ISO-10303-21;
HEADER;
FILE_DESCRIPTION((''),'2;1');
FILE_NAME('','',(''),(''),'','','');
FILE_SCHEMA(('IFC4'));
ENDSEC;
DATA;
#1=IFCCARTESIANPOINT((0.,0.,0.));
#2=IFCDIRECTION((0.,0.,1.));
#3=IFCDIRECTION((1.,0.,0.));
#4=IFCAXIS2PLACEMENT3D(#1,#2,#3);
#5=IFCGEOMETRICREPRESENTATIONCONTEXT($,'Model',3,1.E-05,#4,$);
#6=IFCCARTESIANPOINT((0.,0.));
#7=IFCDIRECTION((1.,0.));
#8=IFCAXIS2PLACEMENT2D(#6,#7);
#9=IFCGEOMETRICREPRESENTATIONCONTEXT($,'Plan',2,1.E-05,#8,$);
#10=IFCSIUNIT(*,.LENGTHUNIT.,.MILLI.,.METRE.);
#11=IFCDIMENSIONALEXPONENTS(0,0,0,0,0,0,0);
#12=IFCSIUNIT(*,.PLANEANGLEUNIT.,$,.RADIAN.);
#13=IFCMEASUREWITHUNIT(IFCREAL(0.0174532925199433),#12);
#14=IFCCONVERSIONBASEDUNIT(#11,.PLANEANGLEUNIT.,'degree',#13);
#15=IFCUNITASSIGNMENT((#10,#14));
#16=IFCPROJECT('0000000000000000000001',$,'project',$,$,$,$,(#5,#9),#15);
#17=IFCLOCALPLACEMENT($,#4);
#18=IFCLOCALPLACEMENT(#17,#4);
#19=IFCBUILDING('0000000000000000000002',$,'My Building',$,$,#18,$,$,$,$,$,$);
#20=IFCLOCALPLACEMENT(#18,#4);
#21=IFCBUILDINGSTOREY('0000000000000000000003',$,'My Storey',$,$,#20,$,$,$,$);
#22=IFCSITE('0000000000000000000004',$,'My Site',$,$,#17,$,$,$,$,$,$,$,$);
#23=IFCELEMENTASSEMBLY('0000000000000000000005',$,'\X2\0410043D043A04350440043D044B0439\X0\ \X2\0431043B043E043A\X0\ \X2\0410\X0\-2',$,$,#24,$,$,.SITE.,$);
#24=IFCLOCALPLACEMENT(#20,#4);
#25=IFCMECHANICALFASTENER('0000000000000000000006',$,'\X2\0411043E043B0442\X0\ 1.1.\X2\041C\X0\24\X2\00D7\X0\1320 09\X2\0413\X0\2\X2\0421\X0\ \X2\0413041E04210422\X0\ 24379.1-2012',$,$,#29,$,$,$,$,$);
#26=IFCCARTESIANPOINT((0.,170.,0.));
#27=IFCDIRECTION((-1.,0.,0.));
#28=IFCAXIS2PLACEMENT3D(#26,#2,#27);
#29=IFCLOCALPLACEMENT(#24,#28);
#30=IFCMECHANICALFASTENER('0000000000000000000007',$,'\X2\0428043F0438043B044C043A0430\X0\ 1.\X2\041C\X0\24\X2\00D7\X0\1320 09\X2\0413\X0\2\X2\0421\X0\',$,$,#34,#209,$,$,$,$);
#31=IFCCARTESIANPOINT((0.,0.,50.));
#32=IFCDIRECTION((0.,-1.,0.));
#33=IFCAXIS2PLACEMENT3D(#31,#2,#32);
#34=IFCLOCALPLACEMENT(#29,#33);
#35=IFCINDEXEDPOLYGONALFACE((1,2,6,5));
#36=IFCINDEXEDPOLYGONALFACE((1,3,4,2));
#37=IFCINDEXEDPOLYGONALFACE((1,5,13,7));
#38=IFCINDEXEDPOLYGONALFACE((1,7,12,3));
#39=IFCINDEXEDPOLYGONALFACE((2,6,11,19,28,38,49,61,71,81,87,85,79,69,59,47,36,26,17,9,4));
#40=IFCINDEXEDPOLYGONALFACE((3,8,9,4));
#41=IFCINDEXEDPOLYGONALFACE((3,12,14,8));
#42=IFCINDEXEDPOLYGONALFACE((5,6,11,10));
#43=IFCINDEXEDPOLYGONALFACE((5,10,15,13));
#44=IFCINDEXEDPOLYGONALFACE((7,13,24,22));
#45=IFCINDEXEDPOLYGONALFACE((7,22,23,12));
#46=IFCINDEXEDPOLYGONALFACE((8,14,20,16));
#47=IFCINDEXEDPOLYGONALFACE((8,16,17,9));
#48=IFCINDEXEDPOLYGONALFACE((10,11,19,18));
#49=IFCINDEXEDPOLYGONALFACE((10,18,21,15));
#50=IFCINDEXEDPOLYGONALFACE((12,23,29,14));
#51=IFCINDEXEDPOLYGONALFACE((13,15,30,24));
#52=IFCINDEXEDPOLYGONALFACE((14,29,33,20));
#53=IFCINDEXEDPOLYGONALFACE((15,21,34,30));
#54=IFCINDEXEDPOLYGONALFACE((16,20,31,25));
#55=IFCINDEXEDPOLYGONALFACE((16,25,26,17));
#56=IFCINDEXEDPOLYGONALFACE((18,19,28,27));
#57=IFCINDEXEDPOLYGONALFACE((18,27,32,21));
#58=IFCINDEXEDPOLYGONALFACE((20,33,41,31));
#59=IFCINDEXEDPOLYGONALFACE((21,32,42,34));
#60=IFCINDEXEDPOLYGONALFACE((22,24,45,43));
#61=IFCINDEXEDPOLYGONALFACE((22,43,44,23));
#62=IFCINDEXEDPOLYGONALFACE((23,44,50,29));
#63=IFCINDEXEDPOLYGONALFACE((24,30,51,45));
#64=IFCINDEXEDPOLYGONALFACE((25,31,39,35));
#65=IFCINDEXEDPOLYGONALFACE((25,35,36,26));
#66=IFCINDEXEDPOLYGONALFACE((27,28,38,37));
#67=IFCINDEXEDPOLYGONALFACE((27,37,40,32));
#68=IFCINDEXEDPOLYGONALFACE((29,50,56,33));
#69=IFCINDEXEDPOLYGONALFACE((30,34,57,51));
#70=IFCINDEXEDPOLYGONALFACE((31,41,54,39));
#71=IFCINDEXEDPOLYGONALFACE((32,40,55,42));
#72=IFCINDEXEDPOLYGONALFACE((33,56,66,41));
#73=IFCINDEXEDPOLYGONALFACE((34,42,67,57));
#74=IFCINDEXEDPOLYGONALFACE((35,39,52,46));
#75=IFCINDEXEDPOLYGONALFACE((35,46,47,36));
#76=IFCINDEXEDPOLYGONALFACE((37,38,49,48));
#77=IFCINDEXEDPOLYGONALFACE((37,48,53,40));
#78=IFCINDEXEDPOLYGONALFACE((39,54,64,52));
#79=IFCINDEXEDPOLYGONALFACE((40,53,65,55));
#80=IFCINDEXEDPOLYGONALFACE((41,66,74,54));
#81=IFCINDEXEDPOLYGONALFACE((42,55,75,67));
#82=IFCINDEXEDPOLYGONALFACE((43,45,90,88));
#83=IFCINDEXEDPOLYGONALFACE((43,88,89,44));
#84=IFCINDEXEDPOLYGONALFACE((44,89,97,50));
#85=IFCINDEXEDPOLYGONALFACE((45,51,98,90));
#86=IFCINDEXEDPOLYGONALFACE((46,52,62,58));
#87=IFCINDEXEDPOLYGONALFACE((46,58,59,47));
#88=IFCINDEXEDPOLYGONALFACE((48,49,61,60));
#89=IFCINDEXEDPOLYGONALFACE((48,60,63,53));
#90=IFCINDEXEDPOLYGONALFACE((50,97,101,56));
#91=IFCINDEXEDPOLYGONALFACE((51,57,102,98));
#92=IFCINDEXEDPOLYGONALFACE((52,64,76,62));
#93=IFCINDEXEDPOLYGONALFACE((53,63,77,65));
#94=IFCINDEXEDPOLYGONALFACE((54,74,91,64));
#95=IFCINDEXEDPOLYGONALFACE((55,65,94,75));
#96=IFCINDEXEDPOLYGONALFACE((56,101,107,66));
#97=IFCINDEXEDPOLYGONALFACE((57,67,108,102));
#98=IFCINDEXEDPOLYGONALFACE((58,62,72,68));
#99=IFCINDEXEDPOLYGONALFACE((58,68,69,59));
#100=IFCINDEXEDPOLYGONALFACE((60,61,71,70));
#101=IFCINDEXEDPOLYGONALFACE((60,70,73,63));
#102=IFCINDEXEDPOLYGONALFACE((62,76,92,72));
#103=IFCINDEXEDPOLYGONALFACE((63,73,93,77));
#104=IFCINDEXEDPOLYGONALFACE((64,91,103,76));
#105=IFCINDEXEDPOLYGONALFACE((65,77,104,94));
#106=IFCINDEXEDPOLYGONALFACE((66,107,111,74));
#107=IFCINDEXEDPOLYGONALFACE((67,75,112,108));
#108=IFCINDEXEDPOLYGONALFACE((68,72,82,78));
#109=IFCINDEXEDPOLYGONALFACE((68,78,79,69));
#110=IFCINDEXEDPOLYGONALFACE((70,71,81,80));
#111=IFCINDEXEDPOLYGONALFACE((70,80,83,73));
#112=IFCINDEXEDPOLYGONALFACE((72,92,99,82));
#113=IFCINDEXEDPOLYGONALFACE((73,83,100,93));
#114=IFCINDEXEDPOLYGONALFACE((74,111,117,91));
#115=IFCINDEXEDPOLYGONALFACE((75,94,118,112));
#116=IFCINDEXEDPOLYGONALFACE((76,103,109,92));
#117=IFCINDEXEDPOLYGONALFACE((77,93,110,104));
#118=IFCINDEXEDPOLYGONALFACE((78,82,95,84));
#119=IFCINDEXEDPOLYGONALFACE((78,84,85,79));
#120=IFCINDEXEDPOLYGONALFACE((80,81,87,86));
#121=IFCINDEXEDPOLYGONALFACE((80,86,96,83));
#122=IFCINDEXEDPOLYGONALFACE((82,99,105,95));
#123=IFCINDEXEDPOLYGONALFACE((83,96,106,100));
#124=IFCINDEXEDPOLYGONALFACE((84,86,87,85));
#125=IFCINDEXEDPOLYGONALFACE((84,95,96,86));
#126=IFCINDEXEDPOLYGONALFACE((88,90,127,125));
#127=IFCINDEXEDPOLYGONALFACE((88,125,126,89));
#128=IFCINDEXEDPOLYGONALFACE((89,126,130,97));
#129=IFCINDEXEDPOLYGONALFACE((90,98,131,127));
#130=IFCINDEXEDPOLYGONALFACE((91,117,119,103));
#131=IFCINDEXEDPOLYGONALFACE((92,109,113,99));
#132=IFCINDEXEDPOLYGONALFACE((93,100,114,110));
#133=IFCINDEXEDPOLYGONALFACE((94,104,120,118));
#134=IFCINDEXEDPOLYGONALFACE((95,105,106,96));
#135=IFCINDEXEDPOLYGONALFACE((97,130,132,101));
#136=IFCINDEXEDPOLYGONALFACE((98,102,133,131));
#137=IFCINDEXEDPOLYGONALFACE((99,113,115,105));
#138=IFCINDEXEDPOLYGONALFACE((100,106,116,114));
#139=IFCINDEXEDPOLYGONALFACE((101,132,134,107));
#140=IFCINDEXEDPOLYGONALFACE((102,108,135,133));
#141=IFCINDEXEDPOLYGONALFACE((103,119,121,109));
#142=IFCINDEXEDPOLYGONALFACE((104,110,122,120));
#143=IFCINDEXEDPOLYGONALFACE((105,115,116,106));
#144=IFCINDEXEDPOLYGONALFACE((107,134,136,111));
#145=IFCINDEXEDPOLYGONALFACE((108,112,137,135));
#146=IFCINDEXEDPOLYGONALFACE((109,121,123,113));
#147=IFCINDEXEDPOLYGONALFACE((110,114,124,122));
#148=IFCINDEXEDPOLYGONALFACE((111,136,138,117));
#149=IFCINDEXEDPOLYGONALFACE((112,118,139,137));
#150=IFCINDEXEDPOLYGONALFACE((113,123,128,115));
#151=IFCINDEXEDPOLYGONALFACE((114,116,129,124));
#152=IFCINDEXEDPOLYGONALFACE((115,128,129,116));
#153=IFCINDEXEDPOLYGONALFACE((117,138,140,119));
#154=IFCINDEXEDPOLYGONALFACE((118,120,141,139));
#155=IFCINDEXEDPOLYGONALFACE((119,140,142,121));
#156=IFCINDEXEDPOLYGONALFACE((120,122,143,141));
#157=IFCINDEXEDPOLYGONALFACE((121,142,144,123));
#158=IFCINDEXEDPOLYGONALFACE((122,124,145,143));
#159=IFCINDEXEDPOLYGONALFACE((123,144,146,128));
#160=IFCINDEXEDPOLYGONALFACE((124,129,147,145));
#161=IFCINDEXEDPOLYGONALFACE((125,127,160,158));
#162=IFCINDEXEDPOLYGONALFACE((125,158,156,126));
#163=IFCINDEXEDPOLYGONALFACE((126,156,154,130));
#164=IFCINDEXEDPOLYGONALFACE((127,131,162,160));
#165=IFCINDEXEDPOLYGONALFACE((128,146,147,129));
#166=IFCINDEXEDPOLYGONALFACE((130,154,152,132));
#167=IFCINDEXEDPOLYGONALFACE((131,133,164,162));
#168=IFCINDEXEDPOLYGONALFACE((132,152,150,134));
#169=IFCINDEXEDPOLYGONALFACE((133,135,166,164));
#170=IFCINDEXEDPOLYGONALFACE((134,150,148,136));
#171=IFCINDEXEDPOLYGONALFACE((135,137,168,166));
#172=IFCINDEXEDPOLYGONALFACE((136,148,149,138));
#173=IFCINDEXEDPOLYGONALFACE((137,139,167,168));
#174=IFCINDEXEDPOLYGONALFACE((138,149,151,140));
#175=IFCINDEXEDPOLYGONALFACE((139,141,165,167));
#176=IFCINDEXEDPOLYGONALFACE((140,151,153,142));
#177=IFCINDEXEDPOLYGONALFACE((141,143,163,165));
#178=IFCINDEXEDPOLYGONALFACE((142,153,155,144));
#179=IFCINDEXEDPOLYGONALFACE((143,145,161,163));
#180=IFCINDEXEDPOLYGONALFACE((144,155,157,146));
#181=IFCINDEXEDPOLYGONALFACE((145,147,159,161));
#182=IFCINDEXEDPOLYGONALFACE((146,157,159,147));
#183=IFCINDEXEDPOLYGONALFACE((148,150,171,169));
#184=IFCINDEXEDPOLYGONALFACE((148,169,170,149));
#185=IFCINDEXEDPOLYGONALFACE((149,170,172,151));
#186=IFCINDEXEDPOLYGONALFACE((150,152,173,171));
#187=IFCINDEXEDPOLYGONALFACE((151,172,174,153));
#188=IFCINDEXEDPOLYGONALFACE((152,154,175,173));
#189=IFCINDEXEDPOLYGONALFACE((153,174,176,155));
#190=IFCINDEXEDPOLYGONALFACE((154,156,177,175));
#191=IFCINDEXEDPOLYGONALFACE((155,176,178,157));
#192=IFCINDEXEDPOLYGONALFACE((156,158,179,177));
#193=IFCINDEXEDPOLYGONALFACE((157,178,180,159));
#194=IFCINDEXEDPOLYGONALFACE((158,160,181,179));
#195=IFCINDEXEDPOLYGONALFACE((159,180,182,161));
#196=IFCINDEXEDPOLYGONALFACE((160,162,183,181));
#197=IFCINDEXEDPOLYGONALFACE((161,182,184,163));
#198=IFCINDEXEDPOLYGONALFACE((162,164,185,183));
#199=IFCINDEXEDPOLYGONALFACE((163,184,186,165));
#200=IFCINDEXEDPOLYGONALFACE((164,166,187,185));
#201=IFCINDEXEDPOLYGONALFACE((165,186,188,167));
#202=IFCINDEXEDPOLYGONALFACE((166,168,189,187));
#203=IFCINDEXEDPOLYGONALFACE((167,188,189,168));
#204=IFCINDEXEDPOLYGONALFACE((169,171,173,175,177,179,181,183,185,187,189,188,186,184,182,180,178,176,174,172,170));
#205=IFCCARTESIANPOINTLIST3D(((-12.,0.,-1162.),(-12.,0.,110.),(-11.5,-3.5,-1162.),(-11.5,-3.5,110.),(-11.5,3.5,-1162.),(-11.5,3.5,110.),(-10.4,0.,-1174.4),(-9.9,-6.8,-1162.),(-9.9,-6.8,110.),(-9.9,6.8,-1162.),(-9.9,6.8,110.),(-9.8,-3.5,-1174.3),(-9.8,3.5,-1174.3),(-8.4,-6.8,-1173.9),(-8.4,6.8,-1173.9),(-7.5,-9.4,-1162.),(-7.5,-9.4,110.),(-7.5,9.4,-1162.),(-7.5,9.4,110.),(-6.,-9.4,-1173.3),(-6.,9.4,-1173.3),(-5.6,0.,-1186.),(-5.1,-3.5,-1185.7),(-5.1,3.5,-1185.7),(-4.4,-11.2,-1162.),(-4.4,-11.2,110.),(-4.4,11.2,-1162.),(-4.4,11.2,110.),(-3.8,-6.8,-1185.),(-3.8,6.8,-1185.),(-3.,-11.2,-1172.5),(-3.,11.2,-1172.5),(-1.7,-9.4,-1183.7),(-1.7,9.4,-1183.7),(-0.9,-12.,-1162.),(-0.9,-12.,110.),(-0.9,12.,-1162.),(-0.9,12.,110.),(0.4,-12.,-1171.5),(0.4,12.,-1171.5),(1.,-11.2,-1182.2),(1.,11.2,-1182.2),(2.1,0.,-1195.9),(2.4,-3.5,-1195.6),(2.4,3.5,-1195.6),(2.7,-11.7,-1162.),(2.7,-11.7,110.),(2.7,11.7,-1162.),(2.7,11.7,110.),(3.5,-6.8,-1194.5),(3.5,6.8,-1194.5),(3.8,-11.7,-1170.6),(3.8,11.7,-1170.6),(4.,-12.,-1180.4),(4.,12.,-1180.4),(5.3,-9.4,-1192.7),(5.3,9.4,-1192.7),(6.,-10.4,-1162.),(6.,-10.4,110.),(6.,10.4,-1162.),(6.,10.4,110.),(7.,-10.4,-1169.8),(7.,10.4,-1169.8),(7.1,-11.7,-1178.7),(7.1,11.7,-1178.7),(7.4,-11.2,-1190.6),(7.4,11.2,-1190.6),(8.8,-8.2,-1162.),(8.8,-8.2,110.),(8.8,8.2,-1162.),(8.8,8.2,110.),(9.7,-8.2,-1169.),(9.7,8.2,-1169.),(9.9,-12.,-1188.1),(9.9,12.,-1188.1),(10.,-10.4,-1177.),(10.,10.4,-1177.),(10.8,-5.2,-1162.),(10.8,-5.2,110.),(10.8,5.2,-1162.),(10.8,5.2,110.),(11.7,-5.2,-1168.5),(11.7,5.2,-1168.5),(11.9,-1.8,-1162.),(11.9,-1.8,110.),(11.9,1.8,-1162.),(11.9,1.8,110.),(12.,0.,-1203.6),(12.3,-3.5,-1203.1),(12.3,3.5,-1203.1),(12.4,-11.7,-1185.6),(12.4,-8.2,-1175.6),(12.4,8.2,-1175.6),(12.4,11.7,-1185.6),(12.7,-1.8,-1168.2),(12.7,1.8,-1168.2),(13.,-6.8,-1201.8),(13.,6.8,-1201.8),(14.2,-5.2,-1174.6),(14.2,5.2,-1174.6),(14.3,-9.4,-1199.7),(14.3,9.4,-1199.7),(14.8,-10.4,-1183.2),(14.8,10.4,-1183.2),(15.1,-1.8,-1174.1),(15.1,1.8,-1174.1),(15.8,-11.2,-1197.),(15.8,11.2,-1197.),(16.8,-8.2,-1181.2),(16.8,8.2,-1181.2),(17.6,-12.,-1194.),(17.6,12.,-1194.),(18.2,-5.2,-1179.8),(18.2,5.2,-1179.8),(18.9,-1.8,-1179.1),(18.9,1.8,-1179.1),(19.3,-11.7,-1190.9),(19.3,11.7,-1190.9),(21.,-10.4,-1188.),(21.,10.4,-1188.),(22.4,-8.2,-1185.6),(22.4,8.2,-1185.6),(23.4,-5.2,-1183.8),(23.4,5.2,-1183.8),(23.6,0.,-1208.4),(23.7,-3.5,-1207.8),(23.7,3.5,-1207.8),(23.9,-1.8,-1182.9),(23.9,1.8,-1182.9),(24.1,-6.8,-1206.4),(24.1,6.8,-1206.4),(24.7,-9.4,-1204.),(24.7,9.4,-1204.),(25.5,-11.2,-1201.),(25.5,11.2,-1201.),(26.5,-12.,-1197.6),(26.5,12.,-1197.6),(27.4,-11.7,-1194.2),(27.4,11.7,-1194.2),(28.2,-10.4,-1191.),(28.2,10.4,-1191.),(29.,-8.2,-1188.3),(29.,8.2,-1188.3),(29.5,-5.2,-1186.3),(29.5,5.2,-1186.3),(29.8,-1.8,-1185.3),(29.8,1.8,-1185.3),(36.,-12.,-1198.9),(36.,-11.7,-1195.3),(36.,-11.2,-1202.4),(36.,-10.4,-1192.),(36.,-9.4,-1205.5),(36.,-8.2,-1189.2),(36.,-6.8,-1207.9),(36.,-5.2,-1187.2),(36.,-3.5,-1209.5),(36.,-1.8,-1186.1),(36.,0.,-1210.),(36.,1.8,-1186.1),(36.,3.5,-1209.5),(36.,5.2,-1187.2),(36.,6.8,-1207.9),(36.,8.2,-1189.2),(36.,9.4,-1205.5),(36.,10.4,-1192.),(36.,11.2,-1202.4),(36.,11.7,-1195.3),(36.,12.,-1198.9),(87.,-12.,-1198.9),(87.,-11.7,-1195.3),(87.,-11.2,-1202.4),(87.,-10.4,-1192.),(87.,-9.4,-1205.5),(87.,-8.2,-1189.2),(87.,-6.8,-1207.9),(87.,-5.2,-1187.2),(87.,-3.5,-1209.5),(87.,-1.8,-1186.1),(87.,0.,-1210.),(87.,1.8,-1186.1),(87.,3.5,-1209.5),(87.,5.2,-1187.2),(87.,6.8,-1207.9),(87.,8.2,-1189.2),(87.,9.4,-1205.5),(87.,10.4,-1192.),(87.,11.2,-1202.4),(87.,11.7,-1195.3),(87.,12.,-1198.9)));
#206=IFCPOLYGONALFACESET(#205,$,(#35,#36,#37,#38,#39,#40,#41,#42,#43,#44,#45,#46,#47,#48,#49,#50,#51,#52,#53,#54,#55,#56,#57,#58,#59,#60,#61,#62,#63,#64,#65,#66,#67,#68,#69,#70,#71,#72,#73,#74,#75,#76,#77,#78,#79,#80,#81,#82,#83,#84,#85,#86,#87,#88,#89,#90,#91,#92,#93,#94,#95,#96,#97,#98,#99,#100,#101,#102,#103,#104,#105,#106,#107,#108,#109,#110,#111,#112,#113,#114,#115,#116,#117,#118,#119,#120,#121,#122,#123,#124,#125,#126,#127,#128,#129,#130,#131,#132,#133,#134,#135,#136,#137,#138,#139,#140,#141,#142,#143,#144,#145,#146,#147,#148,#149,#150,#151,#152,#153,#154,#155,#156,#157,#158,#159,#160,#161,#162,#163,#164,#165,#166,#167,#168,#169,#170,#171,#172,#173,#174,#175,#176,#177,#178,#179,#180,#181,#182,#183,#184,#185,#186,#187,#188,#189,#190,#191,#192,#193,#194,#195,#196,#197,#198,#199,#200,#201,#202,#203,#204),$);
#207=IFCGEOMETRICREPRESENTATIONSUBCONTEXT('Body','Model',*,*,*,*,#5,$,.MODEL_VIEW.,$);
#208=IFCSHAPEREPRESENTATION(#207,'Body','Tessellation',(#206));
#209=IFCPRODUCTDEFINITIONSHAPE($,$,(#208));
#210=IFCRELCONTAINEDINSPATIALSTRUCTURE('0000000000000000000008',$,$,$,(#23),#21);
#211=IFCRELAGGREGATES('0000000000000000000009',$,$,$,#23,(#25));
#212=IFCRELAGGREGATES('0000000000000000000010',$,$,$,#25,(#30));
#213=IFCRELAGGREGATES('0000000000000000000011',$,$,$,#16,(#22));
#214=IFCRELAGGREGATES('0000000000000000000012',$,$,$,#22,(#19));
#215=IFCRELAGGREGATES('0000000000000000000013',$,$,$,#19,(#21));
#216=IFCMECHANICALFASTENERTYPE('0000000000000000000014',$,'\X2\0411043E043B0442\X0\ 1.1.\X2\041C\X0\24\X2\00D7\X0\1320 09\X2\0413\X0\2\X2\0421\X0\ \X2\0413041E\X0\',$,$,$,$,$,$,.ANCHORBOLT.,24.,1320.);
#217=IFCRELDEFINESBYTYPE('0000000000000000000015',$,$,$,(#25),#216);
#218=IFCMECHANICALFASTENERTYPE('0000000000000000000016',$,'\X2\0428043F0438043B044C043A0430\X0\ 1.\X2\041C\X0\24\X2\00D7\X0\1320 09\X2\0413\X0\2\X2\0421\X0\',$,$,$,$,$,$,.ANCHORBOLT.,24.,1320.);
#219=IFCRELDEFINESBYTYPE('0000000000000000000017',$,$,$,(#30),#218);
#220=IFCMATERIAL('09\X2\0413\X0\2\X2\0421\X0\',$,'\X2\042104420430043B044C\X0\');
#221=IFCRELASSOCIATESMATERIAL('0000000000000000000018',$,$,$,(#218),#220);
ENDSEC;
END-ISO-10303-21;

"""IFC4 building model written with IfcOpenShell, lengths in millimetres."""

from ifc_helpers import new_model, entity, si_unit, converted_unit, frame, origin_with_axes, origin_2d_with_axis, place, context, subcontext, project, spatial, source, transform, mapped, material, type_object, type_shapes, element, aggregate, save


model = new_model("IFC4")

# Units and contexts
model_context = context("Model", 3, precision=1e-05, world=origin_with_axes())
plan_context = context("Plan", 2, precision=1e-05, world=origin_2d_with_axis())
body_context = subcontext(model_context, "Body", "Model", "MODEL_VIEW")
ifc_project = project(units=[si_unit("LENGTHUNIT", "METRE", prefix="MILLI"), converted_unit("PLANEANGLEUNIT", "degree", entity("IfcReal", 0.0174532925199433), si_unit("PLANEANGLEUNIT", "RADIAN"), dimensions=[0, 0, 0, 0, 0, 0, 0])], contexts=[model_context, plan_context])

# Site, building, storey
site_placement = place(None, origin_with_axes())
site = spatial("IfcSite", under=ifc_project, at=site_placement, Name="My Site")
building_placement = place(site_placement, origin_with_axes())
building = spatial("IfcBuilding", under=site, at=building_placement, Name="My Building")
storey_placement = place(building_placement, origin_with_axes())
storey = spatial("IfcBuildingStorey", under=building, at=storey_placement, Name="My Storey")

# Shared definitions
placement = place(storey_placement, origin_with_axes())

# Element assembly, mechanical fasteners
assembly_1 = element("IfcElementAssembly", 1, at=placement, inside=storey, Name="Анкерный блок А-2", AssemblyPlace="SITE")
ifc_material_1 = material(Name="09Г2С", Category="Сталь")
mechanical_fastener_type_1 = type_object("IfcMechanicalFastenerType", Name="Шпилька 1.М24×1320 09Г2С", NominalDiameter=24.0, NominalLength=1320.0, PredefinedType="ANCHORBOLT", material=ifc_material_1)
shared_shape_1 = source(frame((0.0, 0.0, 110.0), z_axis=(0.0, 0.0, 1.0), x_axis=(1.0, 0.0, 0.0)), body_context, "Body", "AdvancedSweptSolid", [
    entity("IfcSweptDiskSolid", entity("IfcIndexedPolyCurve", entity("IfcCartesianPointList3D", [[0.0, 0.0, 0.0], [0.0, 0.0, -1272.0], [10.5, 0.0, -1297.5], [36.0, 0.0, -1308.0], [87.0, 0.0, -1308.0]]), [entity("IfcLineIndex", [1, 2]), entity("IfcArcIndex", [2, 3, 4]), entity("IfcLineIndex", [4, 5])]), 12.0),
])
type_shapes(mechanical_fastener_type_1, [shared_shape_1])
mechanical_fastener_type_2 = type_object("IfcMechanicalFastenerType", Name="Болт 1.1.М24×1320 09Г2С ГО", NominalDiameter=24.0, NominalLength=1320.0, PredefinedType="ANCHORBOLT")
mechanical_fastener_1_placement = place(placement, frame((0.0, 170.0, 0.0), z_axis=(0.0, 0.0, 1.0), x_axis=(-1.0, 0.0, 0.0)))
mechanical_fastener_1 = element("IfcMechanicalFastener", 2, at=mechanical_fastener_1_placement, type_object=mechanical_fastener_type_2, Name="Болт 1.1.М24×1320 09Г2С ГОСТ 24379.1-2012")
aggregate(assembly_1, [mechanical_fastener_1])
mechanical_fastener_2_placement = place(mechanical_fastener_1_placement, frame((0.0, 0.0, 50.0), z_axis=(0.0, 0.0, 1.0), x_axis=(0.0, -1.0, 0.0)))
mechanical_fastener_2 = element("IfcMechanicalFastener", 3, at=mechanical_fastener_2_placement, type_object=mechanical_fastener_type_1, Name="Шпилька 1.М24×1320 09Г2С", context=body_context, shape_type="MappedRepresentation", body=[
    mapped(shared_shape_1, transform((0.0, 0.0, 0.0), x_axis=(1.0, 0.0, 0.0), y_axis=(0.0, 1.0, 0.0), z_axis=(0.0, 0.0, 1.0), scale=1.0)),
])

aggregate(mechanical_fastener_1, [mechanical_fastener_2])

save(model, "model.ifc")
